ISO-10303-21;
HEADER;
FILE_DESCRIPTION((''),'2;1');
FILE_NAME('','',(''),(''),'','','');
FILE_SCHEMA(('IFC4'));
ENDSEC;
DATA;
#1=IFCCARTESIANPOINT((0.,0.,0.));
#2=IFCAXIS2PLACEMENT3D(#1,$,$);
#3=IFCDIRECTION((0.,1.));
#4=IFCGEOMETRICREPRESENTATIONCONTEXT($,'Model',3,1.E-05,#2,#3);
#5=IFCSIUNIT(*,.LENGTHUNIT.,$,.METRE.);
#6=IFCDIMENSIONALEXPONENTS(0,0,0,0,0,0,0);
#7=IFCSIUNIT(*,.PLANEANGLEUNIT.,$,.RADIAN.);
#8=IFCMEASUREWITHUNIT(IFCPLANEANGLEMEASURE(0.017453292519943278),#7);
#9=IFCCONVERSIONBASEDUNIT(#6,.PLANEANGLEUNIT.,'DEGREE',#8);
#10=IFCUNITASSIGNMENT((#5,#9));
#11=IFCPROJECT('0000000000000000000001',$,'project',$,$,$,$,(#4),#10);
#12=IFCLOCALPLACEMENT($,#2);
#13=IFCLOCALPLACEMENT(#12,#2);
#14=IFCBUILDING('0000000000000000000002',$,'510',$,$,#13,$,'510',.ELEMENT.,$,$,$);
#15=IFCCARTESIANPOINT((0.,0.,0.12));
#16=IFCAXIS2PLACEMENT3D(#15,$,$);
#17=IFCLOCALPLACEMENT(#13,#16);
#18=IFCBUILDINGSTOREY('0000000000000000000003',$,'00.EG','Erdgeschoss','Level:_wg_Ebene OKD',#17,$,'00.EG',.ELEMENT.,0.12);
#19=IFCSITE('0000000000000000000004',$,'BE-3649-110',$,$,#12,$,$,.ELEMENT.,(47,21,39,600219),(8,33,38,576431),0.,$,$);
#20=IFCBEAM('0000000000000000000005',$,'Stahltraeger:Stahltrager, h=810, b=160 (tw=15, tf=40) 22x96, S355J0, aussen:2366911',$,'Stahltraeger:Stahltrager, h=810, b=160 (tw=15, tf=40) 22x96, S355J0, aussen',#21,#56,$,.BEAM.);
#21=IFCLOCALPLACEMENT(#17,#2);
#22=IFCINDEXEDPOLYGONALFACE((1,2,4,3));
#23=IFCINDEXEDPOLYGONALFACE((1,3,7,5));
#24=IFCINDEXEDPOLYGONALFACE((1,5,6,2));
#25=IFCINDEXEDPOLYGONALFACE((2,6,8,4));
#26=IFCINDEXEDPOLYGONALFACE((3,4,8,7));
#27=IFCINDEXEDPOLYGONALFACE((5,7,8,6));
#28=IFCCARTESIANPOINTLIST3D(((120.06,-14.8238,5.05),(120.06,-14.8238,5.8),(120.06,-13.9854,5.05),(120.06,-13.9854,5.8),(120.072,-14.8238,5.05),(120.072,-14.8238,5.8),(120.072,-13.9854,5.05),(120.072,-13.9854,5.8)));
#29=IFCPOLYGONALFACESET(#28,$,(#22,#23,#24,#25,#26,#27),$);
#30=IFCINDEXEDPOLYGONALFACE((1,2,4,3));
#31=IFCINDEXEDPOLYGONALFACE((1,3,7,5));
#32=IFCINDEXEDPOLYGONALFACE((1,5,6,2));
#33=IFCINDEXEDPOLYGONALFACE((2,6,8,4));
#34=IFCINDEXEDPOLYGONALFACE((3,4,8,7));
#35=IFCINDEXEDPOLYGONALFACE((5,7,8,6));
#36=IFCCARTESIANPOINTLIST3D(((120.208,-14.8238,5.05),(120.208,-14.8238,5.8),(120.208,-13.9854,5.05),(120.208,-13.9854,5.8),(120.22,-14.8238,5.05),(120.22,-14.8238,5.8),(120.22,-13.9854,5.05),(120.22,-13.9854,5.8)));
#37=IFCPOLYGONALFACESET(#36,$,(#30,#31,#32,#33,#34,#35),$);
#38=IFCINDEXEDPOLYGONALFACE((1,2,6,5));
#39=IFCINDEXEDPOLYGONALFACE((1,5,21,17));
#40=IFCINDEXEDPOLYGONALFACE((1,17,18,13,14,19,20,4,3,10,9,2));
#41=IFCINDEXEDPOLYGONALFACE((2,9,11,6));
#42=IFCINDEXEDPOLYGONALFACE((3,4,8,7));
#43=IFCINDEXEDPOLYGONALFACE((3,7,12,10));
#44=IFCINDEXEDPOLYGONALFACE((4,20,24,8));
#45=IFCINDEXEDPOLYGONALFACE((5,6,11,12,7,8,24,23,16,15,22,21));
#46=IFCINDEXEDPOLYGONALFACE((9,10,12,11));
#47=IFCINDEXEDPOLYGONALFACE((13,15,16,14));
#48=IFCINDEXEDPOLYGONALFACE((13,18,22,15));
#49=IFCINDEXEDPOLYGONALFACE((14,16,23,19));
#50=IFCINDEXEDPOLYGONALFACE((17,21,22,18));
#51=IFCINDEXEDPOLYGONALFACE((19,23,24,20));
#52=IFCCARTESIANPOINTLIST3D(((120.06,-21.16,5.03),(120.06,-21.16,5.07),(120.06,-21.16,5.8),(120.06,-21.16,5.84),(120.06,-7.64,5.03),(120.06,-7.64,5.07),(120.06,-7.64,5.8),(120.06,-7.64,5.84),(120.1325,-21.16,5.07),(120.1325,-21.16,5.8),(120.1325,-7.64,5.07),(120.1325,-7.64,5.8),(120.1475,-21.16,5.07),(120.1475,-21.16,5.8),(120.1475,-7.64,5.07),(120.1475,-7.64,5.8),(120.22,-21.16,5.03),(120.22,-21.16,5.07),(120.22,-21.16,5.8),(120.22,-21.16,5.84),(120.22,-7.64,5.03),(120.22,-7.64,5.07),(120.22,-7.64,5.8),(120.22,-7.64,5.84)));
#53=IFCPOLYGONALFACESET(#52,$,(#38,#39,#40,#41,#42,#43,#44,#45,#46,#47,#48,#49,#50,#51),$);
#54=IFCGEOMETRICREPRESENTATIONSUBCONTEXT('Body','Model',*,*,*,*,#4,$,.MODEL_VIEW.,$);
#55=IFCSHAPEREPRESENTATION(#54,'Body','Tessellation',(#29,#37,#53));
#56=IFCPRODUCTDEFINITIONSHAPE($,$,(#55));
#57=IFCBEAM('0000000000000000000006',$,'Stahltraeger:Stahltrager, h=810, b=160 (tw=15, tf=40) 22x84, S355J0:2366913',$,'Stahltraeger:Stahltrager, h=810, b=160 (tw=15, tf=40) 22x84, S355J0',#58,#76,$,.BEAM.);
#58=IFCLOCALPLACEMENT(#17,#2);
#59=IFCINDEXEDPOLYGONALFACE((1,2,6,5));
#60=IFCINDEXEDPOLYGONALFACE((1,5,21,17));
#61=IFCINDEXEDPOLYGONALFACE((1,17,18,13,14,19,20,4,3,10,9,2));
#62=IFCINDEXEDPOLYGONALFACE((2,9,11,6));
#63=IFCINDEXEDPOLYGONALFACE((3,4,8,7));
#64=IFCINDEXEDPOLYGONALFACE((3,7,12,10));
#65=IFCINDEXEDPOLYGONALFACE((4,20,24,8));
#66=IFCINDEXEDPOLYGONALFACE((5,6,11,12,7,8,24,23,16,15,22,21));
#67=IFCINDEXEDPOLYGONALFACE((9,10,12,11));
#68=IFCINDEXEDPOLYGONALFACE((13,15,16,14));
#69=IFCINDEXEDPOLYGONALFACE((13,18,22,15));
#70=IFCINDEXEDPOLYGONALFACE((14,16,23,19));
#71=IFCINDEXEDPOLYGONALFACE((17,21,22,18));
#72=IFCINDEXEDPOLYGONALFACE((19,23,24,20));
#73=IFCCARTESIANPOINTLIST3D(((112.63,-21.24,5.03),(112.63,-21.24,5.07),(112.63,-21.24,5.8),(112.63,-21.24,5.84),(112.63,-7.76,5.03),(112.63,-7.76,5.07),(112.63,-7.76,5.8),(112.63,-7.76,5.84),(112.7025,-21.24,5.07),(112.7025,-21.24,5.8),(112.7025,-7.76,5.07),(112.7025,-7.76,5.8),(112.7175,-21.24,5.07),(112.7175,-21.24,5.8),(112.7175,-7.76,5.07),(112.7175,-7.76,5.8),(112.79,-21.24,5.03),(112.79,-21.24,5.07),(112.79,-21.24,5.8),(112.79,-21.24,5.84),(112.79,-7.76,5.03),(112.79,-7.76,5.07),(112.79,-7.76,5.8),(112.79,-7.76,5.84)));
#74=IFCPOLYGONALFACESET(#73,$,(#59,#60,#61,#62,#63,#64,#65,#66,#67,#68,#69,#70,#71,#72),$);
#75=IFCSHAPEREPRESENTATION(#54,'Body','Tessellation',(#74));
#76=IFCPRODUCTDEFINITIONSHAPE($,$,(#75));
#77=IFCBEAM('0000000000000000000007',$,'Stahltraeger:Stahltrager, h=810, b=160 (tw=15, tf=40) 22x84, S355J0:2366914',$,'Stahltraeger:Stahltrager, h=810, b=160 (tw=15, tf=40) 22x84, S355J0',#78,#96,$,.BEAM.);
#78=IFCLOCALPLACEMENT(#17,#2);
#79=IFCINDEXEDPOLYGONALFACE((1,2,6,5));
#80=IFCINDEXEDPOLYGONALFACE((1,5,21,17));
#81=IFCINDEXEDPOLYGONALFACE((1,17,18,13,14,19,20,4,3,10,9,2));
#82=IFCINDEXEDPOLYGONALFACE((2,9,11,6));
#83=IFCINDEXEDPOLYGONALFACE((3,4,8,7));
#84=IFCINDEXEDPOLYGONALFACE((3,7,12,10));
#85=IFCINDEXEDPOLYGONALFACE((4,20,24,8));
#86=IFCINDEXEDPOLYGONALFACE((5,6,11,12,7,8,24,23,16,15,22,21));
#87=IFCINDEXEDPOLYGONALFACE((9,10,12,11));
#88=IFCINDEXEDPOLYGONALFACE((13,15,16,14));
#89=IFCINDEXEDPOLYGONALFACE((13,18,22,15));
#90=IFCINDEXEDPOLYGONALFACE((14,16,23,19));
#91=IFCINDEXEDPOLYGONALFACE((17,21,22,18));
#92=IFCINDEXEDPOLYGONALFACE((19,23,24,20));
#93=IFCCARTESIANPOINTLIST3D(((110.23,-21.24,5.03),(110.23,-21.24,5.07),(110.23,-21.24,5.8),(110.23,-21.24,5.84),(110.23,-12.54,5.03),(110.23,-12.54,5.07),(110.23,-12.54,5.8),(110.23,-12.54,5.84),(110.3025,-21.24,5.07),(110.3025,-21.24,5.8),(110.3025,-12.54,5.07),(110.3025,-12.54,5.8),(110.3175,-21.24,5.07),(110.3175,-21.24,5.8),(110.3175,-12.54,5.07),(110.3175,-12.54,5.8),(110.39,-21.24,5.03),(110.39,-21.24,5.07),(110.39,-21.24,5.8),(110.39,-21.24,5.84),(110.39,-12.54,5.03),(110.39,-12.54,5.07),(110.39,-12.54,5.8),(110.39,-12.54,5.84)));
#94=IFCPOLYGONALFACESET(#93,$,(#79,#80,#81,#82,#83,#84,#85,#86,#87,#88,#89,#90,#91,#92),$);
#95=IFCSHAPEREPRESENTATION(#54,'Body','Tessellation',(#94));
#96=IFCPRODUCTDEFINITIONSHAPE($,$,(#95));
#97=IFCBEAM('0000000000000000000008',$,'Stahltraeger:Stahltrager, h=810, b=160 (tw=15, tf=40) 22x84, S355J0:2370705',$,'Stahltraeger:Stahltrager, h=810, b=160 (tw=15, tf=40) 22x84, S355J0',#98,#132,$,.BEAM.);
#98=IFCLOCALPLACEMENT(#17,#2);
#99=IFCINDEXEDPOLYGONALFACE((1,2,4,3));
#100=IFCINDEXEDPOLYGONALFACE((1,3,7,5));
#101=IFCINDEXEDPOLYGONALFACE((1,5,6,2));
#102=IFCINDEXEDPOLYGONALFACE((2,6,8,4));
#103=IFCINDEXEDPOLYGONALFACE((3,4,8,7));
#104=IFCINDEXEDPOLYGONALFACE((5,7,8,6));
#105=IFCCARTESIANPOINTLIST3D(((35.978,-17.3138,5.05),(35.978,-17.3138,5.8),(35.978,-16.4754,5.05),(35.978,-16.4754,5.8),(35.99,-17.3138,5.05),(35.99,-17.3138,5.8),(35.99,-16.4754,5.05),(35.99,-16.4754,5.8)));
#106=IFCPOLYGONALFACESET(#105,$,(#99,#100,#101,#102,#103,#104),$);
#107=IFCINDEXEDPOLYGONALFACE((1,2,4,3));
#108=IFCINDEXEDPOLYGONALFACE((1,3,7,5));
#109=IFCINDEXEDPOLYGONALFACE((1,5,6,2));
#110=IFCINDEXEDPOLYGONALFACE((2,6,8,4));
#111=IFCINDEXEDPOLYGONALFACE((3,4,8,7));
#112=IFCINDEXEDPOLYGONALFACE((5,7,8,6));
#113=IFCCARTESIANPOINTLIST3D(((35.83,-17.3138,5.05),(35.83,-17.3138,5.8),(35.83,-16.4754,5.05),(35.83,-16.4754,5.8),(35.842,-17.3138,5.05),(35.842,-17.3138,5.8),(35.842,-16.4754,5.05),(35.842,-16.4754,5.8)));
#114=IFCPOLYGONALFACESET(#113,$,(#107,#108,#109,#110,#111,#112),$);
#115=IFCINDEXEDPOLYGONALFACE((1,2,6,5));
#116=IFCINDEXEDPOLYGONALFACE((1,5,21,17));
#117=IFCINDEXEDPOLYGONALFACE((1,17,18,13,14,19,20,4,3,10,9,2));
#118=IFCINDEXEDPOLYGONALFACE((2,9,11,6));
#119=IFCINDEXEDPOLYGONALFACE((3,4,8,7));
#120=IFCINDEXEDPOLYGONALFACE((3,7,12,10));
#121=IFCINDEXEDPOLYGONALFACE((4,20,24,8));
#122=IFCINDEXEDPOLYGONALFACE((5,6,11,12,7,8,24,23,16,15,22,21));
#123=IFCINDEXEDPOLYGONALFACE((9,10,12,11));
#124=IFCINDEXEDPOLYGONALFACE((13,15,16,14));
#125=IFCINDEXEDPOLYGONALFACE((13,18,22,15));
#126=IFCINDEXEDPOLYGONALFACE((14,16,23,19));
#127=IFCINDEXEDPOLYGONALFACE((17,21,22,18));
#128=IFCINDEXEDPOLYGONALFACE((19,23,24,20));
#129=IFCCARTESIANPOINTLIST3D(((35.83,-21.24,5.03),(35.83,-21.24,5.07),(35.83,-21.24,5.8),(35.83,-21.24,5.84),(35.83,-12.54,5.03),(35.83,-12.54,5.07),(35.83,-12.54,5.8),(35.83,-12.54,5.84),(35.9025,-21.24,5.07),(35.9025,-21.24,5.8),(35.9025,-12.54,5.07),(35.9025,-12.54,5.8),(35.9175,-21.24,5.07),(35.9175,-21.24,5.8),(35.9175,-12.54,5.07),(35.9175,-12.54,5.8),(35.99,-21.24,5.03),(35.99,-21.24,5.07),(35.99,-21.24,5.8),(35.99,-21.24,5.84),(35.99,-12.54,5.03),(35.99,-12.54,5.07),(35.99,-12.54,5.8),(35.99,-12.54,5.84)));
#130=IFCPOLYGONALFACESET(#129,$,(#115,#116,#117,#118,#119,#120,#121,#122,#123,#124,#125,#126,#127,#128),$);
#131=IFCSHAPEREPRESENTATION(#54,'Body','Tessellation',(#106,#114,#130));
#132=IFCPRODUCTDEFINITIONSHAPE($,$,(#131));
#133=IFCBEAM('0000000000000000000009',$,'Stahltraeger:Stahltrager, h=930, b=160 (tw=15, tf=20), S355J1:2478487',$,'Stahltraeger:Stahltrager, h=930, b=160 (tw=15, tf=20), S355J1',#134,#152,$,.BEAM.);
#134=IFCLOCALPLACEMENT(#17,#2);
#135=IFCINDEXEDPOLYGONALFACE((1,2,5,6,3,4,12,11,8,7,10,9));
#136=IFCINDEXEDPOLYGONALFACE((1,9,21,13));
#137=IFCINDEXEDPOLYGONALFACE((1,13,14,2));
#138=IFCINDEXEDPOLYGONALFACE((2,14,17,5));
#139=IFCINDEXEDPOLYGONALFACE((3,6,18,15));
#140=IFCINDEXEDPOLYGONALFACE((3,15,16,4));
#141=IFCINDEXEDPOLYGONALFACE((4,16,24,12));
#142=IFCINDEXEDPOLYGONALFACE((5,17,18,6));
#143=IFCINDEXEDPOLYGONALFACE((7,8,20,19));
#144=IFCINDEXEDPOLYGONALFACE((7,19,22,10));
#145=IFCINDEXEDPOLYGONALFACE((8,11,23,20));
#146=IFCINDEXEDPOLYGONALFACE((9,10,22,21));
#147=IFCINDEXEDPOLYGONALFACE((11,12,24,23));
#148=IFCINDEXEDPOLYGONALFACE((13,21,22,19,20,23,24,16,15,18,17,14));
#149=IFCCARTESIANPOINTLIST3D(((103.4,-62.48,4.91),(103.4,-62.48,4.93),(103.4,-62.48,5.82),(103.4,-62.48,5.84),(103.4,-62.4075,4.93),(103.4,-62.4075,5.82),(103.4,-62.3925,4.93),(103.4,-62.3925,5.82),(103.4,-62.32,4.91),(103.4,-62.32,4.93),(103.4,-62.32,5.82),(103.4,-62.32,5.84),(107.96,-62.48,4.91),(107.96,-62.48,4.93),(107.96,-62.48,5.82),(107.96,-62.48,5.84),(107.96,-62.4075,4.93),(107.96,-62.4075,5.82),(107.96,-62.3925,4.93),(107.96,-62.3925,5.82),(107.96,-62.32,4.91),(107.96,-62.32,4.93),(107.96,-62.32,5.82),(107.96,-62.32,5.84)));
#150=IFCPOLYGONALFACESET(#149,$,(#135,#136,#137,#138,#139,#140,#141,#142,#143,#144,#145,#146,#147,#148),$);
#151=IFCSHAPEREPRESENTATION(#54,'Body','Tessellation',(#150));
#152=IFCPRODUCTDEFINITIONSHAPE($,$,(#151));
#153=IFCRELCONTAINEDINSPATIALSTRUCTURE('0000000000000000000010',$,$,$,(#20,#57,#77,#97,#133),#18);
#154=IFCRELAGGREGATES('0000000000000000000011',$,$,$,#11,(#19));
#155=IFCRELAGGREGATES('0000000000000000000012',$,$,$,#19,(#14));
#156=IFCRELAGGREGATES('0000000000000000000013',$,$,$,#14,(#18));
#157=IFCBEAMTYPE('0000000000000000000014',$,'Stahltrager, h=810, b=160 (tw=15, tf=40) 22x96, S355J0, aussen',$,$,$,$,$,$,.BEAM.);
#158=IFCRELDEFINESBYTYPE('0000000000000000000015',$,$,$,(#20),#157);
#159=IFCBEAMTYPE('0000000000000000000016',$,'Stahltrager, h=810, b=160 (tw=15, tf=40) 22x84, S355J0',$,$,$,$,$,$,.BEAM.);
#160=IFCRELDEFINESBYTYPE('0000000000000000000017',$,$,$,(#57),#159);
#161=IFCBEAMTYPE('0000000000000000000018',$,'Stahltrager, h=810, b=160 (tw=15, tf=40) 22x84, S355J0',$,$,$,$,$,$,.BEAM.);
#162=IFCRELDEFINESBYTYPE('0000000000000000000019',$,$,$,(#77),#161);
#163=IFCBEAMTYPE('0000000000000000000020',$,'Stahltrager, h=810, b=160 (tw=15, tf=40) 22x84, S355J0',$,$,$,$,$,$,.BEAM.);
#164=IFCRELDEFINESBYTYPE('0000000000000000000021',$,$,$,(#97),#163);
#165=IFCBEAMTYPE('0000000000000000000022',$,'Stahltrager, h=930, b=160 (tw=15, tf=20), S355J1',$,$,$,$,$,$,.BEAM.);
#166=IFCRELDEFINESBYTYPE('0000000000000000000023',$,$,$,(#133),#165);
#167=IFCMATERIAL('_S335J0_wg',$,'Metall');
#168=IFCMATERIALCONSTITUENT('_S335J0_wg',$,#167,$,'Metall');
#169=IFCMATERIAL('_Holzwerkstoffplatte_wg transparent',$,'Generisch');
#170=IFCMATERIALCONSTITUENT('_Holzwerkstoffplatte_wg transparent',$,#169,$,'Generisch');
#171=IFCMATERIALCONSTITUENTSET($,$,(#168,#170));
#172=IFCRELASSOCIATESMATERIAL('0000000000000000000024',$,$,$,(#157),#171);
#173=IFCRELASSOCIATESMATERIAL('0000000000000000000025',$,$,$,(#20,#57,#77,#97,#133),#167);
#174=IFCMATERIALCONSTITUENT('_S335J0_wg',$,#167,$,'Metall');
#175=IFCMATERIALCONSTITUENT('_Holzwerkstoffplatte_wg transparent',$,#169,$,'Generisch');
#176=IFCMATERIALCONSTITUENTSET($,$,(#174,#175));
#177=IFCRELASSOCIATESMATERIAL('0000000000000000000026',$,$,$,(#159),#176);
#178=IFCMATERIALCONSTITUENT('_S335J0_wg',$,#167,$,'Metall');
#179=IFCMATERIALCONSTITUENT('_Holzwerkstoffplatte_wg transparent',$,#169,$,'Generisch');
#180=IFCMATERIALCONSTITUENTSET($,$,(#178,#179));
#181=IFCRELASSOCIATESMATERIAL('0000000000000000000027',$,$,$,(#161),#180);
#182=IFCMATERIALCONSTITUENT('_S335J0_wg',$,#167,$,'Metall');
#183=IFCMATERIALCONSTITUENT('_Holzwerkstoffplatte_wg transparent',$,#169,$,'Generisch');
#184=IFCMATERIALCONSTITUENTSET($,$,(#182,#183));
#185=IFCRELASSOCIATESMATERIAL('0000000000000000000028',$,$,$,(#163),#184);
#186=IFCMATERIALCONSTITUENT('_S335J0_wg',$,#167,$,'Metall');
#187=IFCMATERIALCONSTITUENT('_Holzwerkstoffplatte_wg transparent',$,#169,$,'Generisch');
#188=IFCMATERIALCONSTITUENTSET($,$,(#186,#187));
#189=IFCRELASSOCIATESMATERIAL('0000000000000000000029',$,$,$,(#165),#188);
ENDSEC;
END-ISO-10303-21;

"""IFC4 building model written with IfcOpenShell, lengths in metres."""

from ifc_helpers import new_model, entity, si_unit, converted_unit, direction, frame, origin, place, context, subcontext, project, spatial, indexed_curve, outline, extrude, source, transform, mapped, material, constituent, constituent_set, type_object, type_shapes, element, save


model = new_model("IFC4")

# Units and contexts
model_context = context("Model", 3, precision=1e-05, world=origin(), true_north=direction((0.0, 1.0)))
body_context = subcontext(model_context, "Body", "Model", "MODEL_VIEW")
ifc_project = project(units=[si_unit("LENGTHUNIT", "METRE"), converted_unit("PLANEANGLEUNIT", "DEGREE", entity("IfcPlaneAngleMeasure", 0.017453292519943278), si_unit("PLANEANGLEUNIT", "RADIAN"), dimensions=[0, 0, 0, 0, 0, 0, 0])], contexts=[model_context])

# Site, building, storey
site_placement = place(None, origin())
site = spatial("IfcSite", under=ifc_project, at=site_placement, Name="BE-3649-110", CompositionType="ELEMENT", RefLatitude=(47, 21, 39, 600219), RefLongitude=(8, 33, 38, 576431), RefElevation=0.0)
building_placement = place(site_placement, origin())
building = spatial("IfcBuilding", under=site, at=building_placement, Name="510", LongName="510", CompositionType="ELEMENT")
storey_placement = place(building_placement, frame((0.0, 0.0, 0.12)))
storey = spatial("IfcBuildingStorey", under=building, at=storey_placement, Name="00.EG", Description="Erdgeschoss", ObjectType="Level:_wg_Ebene OKD", LongName="00.EG", CompositionType="ELEMENT", Elevation=0.12)

# Beams
ifc_material_1 = material(Name="_S335J0_wg", Category="Metall")
ifc_constituent_1 = constituent(ifc_material_1, Name="_S335J0_wg", Category="Metall")
ifc_material_2 = material(Name="_Holzwerkstoffplatte_wg transparent", Category="Generisch")
ifc_constituent_2 = constituent(ifc_material_2, Name="_Holzwerkstoffplatte_wg transparent", Category="Generisch")
ifc_constituent_set_1 = constituent_set(constituents=[ifc_constituent_1, ifc_constituent_2])
beam_type_1 = type_object("IfcBeamType", Name="Stahltrager, h=810, b=160 (tw=15, tf=40) 22x96, S355J0, aussen", PredefinedType="BEAM", material=ifc_constituent_set_1)
shared_shape_1 = source(origin(), body_context, "Body", "SweptSolid", [
    extrude(outline(indexed_curve([(-0.006, -0.375), (0.006, -0.375), (0.006, 0.375), (-0.006, 0.375), (-0.006, -0.375)], self_intersect=False)), frame((120.066, -13.9854, 5.545), z_axis=(0.0, -1.0, 0.0), x_axis=(-1.0, 0.0, 0.0)), (0.0, 0.0, 1.0), 0.8385),
    extrude(outline(indexed_curve([(-0.006, -0.375), (0.006, -0.375), (0.006, 0.375), (-0.006, 0.375), (-0.006, -0.375)], self_intersect=False)), frame((120.214, -13.9854, 5.545), z_axis=(0.0, -1.0, 0.0), x_axis=(-1.0, 0.0, 0.0)), (0.0, 0.0, 1.0), 0.8385),
    extrude(outline(indexed_curve([(-0.08, -0.405), (0.08, -0.405), (0.08, -0.365), (0.0075, -0.365), (0.0075, 0.365), (0.08, 0.365), (0.08, 0.405), (-0.08, 0.405), (-0.08, 0.365), (-0.0075, 0.365), (-0.0075, -0.365), (-0.08, -0.365), (-0.08, -0.405)], self_intersect=False)), frame((120.14, -7.64, 5.555), z_axis=(0.0, -1.0, 0.0), x_axis=(-1.0, 0.0, 0.0)), (0.0, 0.0, 1.0), 13.52),
])
type_shapes(beam_type_1, [shared_shape_1])
beam_1_placement = place(storey_placement, frame((0.0, 0.0, -0.12)))
element("IfcBeam", 1, at=beam_1_placement, inside=storey, type_object=beam_type_1, material=ifc_material_1, Name="Stahltraeger:Stahltrager, h=810, b=160 (tw=15, tf=40) 22x96, S355J0, aussen:2366911", ObjectType="Stahltraeger:Stahltrager, h=810, b=160 (tw=15, tf=40) 22x96, S355J0, aussen", PredefinedType="BEAM", context=body_context, shape_type="MappedRepresentation", body=[
    mapped(shared_shape_1, transform((0.0, 0.0, 0.0), scale=1.0)),
])
ifc_constituent_3 = constituent(ifc_material_1, Name="_S335J0_wg", Category="Metall")
ifc_constituent_4 = constituent(ifc_material_2, Name="_Holzwerkstoffplatte_wg transparent", Category="Generisch")
ifc_constituent_set_2 = constituent_set(constituents=[ifc_constituent_3, ifc_constituent_4])
beam_type_2 = type_object("IfcBeamType", Name="Stahltrager, h=810, b=160 (tw=15, tf=40) 22x84, S355J0", PredefinedType="BEAM", material=ifc_constituent_set_2)
shared_shape_2 = source(origin(), body_context, "Body", "SweptSolid", [
    extrude(outline(indexed_curve([(-0.08, -0.405), (0.08, -0.405), (0.08, -0.365), (0.0075, -0.365), (0.0075, 0.365), (0.08, 0.365), (0.08, 0.405), (-0.08, 0.405), (-0.08, 0.365), (-0.0075, 0.365), (-0.0075, -0.365), (-0.08, -0.365), (-0.08, -0.405)], self_intersect=False)), frame((112.71, -7.76, 5.555), z_axis=(0.0, -1.0, 0.0), x_axis=(-1.0, 0.0, 0.0)), (0.0, 0.0, 1.0), 13.48),
])
type_shapes(beam_type_2, [shared_shape_2])
beam_2_placement = place(storey_placement, frame((0.0, 0.0, -0.12)))
element("IfcBeam", 2, at=beam_2_placement, inside=storey, type_object=beam_type_2, material=ifc_material_1, Name="Stahltraeger:Stahltrager, h=810, b=160 (tw=15, tf=40) 22x84, S355J0:2366913", ObjectType="Stahltraeger:Stahltrager, h=810, b=160 (tw=15, tf=40) 22x84, S355J0", PredefinedType="BEAM", context=body_context, shape_type="MappedRepresentation", body=[
    mapped(shared_shape_2, transform((0.0, 0.0, 0.0), scale=1.0)),
])
ifc_constituent_5 = constituent(ifc_material_1, Name="_S335J0_wg", Category="Metall")
ifc_constituent_6 = constituent(ifc_material_2, Name="_Holzwerkstoffplatte_wg transparent", Category="Generisch")
ifc_constituent_set_3 = constituent_set(constituents=[ifc_constituent_5, ifc_constituent_6])
beam_type_3 = type_object("IfcBeamType", Name="Stahltrager, h=810, b=160 (tw=15, tf=40) 22x84, S355J0", PredefinedType="BEAM", material=ifc_constituent_set_3)
shared_shape_3 = source(origin(), body_context, "Body", "SweptSolid", [
    extrude(outline(indexed_curve([(-0.08, -0.405), (0.08, -0.405), (0.08, -0.365), (0.0075, -0.365), (0.0075, 0.365), (0.08, 0.365), (0.08, 0.405), (-0.08, 0.405), (-0.08, 0.365), (-0.0075, 0.365), (-0.0075, -0.365), (-0.08, -0.365), (-0.08, -0.405)], self_intersect=False)), frame((110.31, -12.54, 5.555), z_axis=(0.0, -1.0, 0.0), x_axis=(-1.0, 0.0, 0.0)), (0.0, 0.0, 1.0), 8.7),
])
type_shapes(beam_type_3, [shared_shape_3])
beam_3_placement = place(storey_placement, frame((0.0, 0.0, -0.12)))
element("IfcBeam", 3, at=beam_3_placement, inside=storey, type_object=beam_type_3, material=ifc_material_1, Name="Stahltraeger:Stahltrager, h=810, b=160 (tw=15, tf=40) 22x84, S355J0:2366914", ObjectType="Stahltraeger:Stahltrager, h=810, b=160 (tw=15, tf=40) 22x84, S355J0", PredefinedType="BEAM", context=body_context, shape_type="MappedRepresentation", body=[
    mapped(shared_shape_3, transform((0.0, 0.0, 0.0), scale=1.0)),
])
ifc_constituent_7 = constituent(ifc_material_1, Name="_S335J0_wg", Category="Metall")
ifc_constituent_8 = constituent(ifc_material_2, Name="_Holzwerkstoffplatte_wg transparent", Category="Generisch")
ifc_constituent_set_4 = constituent_set(constituents=[ifc_constituent_7, ifc_constituent_8])
beam_type_4 = type_object("IfcBeamType", Name="Stahltrager, h=810, b=160 (tw=15, tf=40) 22x84, S355J0", PredefinedType="BEAM", material=ifc_constituent_set_4)
shared_shape_4 = source(origin(), body_context, "Body", "SweptSolid", [
    extrude(outline(indexed_curve([(-0.006, -0.375), (0.006, -0.375), (0.006, 0.375), (-0.006, 0.375), (-0.006, -0.375)], self_intersect=False)), frame((35.984, -16.4754, 5.545), z_axis=(0.0, -1.0, 0.0), x_axis=(-1.0, 0.0, 0.0)), (0.0, 0.0, 1.0), 0.8385),
    extrude(outline(indexed_curve([(-0.006, -0.375), (0.006, -0.375), (0.006, 0.375), (-0.006, 0.375), (-0.006, -0.375)], self_intersect=False)), frame((35.836, -16.4754, 5.545), z_axis=(0.0, -1.0, 0.0), x_axis=(-1.0, 0.0, 0.0)), (0.0, 0.0, 1.0), 0.8385),
    extrude(outline(indexed_curve([(-0.08, -0.405), (0.08, -0.405), (0.08, -0.365), (0.0075, -0.365), (0.0075, 0.365), (0.08, 0.365), (0.08, 0.405), (-0.08, 0.405), (-0.08, 0.365), (-0.0075, 0.365), (-0.0075, -0.365), (-0.08, -0.365), (-0.08, -0.405)], self_intersect=False)), frame((35.91, -12.54, 5.555), z_axis=(0.0, -1.0, 0.0), x_axis=(-1.0, 0.0, 0.0)), (0.0, 0.0, 1.0), 8.7),
])
type_shapes(beam_type_4, [shared_shape_4])
beam_4_placement = place(storey_placement, frame((0.0, 0.0, -0.12)))
element("IfcBeam", 4, at=beam_4_placement, inside=storey, type_object=beam_type_4, material=ifc_material_1, Name="Stahltraeger:Stahltrager, h=810, b=160 (tw=15, tf=40) 22x84, S355J0:2370705", ObjectType="Stahltraeger:Stahltrager, h=810, b=160 (tw=15, tf=40) 22x84, S355J0", PredefinedType="BEAM", context=body_context, shape_type="MappedRepresentation", body=[
    mapped(shared_shape_4, transform((0.0, 0.0, 0.0), scale=1.0)),
])
ifc_constituent_9 = constituent(ifc_material_1, Name="_S335J0_wg", Category="Metall")
ifc_constituent_10 = constituent(ifc_material_2, Name="_Holzwerkstoffplatte_wg transparent", Category="Generisch")
ifc_constituent_set_5 = constituent_set(constituents=[ifc_constituent_9, ifc_constituent_10])
beam_type_5 = type_object("IfcBeamType", Name="Stahltrager, h=930, b=160 (tw=15, tf=20), S355J1", PredefinedType="BEAM", material=ifc_constituent_set_5)
shared_shape_5 = source(origin(), body_context, "Body", "SweptSolid", [
    extrude(outline(indexed_curve([(-0.465, -0.08), (-0.445, -0.08), (-0.445, -0.0075), (0.445, -0.0075), (0.445, -0.08), (0.465, -0.08), (0.465, 0.08), (0.445, 0.08), (0.445, 0.0075), (-0.445, 0.0075), (-0.445, 0.08), (-0.465, 0.08), (-0.465, -0.08)], self_intersect=False)), frame((103.4, -62.4, 5.495), z_axis=(1.0, 0.0, 0.0), x_axis=(0.0, 0.0, -1.0)), (0.0, 0.0, 1.0), 4.56),
])
type_shapes(beam_type_5, [shared_shape_5])
beam_5_placement = place(storey_placement, frame((0.0, 0.0, -0.12)))
element("IfcBeam", 5, at=beam_5_placement, inside=storey, type_object=beam_type_5, material=ifc_material_1, Name="Stahltraeger:Stahltrager, h=930, b=160 (tw=15, tf=20), S355J1:2478487", ObjectType="Stahltraeger:Stahltrager, h=930, b=160 (tw=15, tf=20), S355J1", PredefinedType="BEAM", context=body_context, shape_type="MappedRepresentation", body=[
    mapped(shared_shape_5, transform((0.0, 0.0, 0.0), scale=1.0)),
])

save(model, "model.ifc")
